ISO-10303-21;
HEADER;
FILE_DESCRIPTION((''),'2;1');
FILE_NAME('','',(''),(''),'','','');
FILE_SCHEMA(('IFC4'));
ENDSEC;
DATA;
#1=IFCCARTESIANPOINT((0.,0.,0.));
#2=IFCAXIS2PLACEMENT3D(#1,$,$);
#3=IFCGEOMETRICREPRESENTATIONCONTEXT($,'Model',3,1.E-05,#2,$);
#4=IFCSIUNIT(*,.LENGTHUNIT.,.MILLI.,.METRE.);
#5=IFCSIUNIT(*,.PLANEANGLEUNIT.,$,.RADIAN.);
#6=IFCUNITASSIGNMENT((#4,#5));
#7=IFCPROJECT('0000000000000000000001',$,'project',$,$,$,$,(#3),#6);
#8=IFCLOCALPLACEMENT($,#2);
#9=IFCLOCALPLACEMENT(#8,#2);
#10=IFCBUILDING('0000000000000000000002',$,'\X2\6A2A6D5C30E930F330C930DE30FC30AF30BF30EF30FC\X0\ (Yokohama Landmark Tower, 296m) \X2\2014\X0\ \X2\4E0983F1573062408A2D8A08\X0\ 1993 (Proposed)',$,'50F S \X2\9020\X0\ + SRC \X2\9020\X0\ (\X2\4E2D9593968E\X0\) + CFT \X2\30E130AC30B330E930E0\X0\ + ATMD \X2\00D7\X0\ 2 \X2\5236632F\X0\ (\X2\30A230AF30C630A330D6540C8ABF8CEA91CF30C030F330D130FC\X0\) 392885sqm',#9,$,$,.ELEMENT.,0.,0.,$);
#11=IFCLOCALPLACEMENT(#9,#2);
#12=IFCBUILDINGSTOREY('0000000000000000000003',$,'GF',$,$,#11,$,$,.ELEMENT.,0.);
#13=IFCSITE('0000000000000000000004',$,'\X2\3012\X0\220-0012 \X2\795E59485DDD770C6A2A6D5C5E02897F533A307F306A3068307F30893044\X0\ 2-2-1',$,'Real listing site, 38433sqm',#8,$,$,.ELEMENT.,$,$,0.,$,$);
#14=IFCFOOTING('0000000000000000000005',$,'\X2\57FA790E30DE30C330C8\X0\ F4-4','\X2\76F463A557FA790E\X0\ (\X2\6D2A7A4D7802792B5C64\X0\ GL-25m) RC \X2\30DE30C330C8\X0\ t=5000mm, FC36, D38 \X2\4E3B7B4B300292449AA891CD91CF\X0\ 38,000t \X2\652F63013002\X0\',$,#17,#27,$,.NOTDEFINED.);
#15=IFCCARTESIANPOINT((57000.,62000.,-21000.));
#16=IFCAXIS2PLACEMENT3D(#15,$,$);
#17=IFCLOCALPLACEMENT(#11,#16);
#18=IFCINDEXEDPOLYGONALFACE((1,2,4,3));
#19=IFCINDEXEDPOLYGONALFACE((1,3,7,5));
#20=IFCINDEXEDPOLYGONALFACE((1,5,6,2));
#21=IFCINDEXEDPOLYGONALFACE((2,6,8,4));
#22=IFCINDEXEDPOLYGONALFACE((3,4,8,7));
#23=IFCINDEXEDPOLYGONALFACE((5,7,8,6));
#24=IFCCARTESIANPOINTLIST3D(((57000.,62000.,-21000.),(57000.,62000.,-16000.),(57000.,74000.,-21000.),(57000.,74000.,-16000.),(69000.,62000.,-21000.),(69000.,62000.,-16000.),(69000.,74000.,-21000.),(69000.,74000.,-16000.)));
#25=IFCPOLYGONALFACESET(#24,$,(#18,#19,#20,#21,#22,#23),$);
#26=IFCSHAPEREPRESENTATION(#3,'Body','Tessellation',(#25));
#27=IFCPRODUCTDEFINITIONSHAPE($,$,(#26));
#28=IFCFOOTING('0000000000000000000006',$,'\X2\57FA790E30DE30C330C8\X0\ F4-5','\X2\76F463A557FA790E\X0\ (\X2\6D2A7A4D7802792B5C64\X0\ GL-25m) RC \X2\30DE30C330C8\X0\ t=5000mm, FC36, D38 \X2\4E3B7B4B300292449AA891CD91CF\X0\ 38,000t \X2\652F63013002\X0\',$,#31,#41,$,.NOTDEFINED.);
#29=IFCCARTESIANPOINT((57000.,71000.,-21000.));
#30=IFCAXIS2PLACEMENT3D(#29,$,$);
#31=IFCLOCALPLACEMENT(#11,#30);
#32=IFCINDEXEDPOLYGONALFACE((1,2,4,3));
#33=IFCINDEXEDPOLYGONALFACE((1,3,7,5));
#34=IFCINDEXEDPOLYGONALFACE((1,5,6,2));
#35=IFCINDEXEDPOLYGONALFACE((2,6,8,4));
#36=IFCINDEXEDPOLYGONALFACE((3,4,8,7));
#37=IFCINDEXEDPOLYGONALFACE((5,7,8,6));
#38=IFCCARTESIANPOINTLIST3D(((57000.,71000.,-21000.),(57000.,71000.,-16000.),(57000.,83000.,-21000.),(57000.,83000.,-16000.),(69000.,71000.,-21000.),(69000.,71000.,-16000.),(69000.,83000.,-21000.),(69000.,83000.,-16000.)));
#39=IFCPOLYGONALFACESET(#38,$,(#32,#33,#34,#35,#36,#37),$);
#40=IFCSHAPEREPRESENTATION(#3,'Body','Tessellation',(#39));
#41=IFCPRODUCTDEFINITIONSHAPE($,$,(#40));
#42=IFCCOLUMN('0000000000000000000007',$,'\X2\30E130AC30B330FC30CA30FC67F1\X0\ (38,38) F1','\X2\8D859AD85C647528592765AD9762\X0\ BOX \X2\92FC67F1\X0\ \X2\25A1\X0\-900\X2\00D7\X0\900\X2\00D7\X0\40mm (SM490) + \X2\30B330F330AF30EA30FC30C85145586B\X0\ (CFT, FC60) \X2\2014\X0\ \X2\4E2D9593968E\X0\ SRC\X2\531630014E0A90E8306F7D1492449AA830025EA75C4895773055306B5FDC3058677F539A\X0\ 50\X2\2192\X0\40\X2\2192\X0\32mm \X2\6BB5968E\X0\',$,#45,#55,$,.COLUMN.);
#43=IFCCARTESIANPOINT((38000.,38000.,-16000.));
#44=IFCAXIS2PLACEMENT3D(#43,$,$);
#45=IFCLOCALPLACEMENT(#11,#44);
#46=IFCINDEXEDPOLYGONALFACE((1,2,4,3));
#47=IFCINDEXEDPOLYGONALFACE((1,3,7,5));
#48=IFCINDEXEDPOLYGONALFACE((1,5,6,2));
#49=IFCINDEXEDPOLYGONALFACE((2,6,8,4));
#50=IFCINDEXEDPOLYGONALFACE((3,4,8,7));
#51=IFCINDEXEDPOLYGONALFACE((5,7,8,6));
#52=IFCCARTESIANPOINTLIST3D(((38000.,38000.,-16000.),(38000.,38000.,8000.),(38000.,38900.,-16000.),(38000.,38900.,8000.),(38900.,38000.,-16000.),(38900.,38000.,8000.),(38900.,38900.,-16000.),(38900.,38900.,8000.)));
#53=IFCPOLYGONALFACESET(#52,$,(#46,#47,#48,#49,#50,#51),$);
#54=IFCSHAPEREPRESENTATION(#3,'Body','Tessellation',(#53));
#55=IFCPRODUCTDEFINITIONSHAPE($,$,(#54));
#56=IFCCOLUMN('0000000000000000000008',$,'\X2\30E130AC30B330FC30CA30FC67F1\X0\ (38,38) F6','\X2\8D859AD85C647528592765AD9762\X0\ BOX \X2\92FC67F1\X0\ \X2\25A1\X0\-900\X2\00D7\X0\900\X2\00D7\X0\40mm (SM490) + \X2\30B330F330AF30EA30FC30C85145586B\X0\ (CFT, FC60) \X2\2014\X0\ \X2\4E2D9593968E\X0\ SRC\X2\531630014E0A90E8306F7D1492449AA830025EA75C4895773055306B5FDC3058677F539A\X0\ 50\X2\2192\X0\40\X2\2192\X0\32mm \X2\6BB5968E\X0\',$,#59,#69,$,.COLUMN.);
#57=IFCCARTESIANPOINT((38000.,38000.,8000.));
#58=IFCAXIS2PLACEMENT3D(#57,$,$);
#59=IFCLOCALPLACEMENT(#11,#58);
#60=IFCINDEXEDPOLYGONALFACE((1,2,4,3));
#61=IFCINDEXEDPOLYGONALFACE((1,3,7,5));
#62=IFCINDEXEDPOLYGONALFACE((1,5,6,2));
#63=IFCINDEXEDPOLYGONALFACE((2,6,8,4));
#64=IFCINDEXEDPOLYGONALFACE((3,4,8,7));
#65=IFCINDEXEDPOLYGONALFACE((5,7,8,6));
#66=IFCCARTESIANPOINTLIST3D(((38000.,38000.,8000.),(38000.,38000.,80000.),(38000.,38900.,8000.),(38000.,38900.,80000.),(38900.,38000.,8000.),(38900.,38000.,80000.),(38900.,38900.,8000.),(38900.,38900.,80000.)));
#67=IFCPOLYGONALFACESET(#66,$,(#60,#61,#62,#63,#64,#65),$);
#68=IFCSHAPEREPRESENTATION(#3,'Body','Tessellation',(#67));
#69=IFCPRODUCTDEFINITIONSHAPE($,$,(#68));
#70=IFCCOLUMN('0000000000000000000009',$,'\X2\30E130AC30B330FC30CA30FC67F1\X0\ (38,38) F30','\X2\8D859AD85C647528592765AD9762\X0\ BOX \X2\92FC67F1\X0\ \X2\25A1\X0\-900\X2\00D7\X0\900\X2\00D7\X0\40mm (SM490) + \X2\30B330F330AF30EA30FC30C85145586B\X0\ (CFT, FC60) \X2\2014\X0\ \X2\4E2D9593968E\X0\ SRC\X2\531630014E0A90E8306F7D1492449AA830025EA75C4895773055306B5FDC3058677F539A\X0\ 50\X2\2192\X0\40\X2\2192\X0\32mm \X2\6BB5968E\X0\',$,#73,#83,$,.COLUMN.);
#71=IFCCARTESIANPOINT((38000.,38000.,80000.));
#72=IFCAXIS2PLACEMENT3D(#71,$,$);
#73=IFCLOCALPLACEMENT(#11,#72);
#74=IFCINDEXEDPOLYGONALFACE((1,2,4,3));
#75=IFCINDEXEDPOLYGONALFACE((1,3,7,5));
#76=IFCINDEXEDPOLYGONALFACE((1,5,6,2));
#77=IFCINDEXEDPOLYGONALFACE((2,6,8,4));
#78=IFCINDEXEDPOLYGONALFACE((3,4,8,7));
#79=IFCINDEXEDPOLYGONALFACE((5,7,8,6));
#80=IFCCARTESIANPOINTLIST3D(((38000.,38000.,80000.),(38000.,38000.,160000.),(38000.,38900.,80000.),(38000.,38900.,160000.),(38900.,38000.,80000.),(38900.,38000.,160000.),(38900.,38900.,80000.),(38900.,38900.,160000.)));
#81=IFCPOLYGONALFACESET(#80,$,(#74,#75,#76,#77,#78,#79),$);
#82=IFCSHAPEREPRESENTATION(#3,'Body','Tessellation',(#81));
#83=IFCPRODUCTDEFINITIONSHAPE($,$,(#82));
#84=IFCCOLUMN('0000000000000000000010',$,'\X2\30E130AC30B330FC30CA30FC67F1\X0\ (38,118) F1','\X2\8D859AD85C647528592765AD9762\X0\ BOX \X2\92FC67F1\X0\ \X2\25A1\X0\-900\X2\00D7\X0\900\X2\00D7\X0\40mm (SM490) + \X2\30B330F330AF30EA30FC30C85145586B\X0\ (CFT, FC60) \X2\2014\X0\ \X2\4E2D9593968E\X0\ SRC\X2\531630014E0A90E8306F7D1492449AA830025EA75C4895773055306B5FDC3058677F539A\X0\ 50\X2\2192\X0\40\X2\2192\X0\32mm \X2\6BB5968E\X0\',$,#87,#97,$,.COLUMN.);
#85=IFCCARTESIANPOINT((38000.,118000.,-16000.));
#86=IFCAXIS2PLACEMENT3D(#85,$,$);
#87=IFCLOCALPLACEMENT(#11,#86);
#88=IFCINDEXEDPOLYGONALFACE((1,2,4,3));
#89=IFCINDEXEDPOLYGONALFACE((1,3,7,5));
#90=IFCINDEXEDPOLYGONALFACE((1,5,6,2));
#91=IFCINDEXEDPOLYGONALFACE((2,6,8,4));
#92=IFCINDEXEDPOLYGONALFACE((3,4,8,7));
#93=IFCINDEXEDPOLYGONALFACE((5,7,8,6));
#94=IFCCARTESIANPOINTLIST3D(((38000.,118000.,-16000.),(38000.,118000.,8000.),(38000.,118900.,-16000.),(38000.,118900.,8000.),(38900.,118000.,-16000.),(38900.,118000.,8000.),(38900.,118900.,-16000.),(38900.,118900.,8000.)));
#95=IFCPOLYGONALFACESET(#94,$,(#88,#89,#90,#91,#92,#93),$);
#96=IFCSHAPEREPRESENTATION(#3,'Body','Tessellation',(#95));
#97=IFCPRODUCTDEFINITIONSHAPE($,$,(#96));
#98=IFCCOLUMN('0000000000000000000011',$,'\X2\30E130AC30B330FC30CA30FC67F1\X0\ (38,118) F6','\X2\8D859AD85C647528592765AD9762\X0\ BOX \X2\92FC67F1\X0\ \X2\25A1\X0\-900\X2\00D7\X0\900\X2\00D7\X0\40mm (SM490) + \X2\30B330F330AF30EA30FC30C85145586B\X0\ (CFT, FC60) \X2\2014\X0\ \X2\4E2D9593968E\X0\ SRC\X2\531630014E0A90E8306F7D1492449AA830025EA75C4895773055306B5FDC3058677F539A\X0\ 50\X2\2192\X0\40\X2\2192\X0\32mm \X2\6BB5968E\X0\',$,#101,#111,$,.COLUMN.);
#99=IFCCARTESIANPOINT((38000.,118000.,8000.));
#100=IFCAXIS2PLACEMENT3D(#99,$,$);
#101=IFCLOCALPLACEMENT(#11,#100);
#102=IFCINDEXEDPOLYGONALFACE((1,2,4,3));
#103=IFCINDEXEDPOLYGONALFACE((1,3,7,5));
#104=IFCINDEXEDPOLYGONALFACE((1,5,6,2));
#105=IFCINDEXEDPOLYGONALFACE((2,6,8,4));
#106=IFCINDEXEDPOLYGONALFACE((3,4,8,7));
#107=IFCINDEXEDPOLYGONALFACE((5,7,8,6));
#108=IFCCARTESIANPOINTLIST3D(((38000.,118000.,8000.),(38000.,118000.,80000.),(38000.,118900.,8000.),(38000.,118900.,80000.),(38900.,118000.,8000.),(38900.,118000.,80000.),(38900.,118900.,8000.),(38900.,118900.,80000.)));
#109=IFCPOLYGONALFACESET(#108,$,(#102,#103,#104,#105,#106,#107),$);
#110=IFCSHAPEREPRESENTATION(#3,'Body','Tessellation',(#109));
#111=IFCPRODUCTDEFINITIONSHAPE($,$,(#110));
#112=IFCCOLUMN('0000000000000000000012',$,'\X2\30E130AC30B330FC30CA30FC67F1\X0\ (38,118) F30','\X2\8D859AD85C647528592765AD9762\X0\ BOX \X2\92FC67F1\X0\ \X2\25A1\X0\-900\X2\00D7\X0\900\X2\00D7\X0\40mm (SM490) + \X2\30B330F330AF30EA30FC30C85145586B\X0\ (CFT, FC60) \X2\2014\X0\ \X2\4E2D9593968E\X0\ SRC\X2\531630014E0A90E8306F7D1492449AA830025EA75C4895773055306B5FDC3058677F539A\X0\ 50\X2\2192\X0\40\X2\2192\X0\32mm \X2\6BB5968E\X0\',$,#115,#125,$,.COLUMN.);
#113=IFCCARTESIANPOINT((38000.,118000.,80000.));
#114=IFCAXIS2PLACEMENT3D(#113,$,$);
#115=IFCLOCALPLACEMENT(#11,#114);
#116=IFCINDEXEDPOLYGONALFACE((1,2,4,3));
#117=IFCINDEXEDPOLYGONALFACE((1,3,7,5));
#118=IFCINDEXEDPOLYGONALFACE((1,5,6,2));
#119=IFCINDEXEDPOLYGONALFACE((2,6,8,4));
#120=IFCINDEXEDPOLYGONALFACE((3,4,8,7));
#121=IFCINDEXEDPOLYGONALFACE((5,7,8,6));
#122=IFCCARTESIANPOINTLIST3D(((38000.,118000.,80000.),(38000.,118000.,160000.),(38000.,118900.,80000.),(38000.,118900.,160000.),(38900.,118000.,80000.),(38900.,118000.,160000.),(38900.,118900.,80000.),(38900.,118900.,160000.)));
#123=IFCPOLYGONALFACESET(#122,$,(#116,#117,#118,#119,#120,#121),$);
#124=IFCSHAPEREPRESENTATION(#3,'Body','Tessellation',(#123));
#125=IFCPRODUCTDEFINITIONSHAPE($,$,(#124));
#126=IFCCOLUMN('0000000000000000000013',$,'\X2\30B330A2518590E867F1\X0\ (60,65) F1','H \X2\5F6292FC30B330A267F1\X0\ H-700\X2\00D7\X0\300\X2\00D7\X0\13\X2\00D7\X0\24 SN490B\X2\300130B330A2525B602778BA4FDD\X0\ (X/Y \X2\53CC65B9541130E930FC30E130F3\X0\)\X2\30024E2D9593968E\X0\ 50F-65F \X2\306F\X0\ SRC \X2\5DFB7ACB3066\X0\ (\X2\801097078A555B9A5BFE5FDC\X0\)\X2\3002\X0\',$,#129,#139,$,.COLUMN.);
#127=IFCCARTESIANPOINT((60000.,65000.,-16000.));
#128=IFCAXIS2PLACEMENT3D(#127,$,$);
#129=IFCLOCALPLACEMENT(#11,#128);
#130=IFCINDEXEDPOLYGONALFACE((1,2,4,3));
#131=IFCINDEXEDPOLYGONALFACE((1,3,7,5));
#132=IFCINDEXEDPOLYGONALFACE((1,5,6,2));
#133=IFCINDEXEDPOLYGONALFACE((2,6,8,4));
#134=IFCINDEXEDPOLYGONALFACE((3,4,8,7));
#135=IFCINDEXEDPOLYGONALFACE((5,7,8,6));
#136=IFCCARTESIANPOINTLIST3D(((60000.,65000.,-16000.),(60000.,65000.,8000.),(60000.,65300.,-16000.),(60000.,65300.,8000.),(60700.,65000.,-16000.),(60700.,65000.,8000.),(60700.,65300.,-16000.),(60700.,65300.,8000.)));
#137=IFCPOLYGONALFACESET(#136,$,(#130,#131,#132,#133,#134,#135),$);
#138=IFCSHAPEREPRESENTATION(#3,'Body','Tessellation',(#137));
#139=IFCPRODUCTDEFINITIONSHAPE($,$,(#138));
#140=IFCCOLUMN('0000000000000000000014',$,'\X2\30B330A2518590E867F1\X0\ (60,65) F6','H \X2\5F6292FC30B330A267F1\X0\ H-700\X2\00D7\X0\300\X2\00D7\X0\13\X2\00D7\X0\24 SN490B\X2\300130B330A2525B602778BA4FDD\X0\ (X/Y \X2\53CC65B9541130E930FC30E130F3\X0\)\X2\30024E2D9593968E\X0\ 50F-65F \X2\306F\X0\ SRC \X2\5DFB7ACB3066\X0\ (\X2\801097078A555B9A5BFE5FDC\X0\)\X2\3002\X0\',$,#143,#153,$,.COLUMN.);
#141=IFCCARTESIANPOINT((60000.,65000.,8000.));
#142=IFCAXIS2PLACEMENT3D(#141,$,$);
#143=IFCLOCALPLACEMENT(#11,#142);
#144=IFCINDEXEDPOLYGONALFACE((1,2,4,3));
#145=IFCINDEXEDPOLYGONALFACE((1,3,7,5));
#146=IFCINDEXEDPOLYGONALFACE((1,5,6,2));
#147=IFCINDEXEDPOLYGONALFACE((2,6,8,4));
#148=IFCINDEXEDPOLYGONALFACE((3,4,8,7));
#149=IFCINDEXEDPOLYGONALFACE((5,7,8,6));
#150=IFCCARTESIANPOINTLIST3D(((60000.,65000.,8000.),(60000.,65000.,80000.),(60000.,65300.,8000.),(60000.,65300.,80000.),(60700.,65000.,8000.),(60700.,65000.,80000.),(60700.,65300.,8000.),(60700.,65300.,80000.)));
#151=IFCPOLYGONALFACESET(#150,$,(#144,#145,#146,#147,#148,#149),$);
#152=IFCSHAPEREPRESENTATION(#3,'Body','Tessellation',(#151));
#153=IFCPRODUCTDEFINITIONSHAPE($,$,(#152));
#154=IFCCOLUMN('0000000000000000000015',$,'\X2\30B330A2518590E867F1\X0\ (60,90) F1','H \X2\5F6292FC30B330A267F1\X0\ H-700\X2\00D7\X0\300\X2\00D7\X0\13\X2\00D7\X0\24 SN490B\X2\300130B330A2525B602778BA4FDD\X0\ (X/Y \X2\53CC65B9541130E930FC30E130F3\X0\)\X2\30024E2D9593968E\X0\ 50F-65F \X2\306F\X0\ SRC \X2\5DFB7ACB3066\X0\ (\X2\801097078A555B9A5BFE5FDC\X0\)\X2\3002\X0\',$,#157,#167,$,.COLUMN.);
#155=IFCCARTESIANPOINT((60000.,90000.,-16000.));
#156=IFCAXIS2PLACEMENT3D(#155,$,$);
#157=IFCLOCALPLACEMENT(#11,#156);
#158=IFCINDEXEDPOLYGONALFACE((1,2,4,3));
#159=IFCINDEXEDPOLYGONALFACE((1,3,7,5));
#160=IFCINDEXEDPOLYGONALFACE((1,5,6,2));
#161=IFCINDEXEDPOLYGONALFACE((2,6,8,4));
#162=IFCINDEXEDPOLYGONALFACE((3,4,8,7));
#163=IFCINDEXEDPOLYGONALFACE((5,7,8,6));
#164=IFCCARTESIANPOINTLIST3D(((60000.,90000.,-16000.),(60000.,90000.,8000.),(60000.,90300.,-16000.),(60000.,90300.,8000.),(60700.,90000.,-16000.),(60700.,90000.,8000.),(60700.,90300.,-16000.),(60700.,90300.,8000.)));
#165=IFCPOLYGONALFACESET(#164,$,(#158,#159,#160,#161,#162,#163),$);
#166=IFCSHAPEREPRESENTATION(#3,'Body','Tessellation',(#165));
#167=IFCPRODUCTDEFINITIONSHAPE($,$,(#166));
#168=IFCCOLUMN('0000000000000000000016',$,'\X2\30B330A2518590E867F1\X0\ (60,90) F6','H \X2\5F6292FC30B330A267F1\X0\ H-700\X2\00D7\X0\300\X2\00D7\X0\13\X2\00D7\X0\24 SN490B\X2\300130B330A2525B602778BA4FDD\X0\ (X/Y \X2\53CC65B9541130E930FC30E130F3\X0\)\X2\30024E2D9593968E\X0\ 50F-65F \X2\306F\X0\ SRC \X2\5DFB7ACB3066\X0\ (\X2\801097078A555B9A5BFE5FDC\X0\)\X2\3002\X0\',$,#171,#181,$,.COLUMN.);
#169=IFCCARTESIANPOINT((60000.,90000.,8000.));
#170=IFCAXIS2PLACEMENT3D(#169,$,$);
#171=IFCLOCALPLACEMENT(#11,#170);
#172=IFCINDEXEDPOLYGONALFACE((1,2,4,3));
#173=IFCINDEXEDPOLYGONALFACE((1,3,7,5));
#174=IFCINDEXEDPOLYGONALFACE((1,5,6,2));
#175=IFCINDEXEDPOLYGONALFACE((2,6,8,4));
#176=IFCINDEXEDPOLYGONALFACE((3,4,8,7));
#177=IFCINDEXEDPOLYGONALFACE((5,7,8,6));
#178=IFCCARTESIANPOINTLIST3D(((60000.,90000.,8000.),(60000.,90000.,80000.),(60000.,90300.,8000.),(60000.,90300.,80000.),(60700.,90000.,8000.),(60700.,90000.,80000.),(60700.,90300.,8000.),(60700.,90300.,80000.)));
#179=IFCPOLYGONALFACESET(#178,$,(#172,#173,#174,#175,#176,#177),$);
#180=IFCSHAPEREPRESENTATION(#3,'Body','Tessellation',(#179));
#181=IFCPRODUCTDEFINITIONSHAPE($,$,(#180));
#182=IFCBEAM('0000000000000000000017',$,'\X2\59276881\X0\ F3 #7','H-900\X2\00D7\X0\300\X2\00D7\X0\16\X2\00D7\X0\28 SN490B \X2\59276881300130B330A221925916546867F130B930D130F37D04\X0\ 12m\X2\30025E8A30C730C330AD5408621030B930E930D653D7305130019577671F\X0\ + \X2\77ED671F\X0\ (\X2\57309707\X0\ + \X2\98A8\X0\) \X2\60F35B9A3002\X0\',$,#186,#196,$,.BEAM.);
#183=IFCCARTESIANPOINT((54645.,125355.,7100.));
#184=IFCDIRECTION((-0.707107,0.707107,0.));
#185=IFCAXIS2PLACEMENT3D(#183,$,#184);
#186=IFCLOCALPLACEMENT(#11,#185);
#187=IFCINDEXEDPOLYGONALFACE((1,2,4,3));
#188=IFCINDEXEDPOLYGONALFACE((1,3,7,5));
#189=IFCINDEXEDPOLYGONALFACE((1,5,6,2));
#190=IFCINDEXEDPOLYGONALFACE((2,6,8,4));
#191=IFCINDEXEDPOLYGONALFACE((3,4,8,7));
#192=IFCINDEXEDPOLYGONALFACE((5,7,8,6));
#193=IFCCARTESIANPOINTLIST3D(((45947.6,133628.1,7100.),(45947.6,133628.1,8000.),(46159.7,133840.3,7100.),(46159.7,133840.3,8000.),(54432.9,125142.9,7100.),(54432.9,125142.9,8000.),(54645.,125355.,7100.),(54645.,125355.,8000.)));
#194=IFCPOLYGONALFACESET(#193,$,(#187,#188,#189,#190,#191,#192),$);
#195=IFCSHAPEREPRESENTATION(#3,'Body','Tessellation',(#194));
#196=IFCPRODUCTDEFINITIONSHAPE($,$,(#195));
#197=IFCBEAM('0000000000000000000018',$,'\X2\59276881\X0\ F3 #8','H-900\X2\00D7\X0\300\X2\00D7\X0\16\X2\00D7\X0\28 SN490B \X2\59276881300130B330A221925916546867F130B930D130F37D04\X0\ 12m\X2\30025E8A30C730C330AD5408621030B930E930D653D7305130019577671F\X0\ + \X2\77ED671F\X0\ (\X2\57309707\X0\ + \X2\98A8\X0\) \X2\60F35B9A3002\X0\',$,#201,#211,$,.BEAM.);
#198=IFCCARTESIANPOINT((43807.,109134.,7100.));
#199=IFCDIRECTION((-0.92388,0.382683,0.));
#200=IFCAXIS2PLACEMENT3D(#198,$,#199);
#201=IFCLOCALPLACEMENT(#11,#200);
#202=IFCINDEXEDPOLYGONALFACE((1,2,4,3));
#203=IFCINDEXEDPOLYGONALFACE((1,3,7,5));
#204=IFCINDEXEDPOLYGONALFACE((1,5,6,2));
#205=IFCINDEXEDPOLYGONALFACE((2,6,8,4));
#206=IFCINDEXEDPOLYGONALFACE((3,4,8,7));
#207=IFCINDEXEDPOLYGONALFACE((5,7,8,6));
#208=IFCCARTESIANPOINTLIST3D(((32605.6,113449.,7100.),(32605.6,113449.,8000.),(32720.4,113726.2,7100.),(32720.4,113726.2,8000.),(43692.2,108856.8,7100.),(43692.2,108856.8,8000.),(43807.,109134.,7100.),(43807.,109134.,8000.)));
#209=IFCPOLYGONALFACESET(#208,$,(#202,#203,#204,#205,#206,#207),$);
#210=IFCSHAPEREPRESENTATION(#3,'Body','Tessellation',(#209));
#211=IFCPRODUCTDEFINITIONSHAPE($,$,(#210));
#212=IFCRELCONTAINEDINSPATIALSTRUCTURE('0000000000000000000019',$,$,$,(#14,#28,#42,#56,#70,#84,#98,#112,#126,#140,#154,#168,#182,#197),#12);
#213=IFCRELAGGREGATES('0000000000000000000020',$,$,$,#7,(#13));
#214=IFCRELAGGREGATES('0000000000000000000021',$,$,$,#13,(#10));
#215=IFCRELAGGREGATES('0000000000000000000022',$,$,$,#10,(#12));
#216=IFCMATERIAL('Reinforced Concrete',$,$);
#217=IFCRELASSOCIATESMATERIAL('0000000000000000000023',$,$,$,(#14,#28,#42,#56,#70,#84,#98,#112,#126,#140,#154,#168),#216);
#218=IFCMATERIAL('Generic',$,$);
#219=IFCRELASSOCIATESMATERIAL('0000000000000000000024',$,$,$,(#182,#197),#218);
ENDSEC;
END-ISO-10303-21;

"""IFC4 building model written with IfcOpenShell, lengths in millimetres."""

from ifc_helpers import new_model, si_unit, frame, frame_2d, origin, place, context, project, spatial, rectangle, extrude, material, element, save


model = new_model("IFC4")

# Units and contexts
model_context = context("Model", 3, precision=1e-05, world=origin())
ifc_project = project(units=[si_unit("LENGTHUNIT", "METRE", prefix="MILLI"), si_unit("PLANEANGLEUNIT", "RADIAN")], contexts=[model_context])

# Site, building, storey
site_placement = place(None, origin())
site = spatial("IfcSite", under=ifc_project, at=site_placement, Name="〒220-0012 神奈川県横浜市西区みなとみらい 2-2-1", ObjectType="Real listing site, 38433sqm", CompositionType="ELEMENT", RefElevation=0.0)
building_placement = place(site_placement, origin())
building = spatial("IfcBuilding", under=site, at=building_placement, Name="横浜ランドマークタワー (Yokohama Landmark Tower, 296m) — 三菱地所設計 1993 (Proposed)", ObjectType="50F S 造 + SRC 造 (中間階) + CFT メガコラム + ATMD × 2 制振 (アクティブ同調質量ダンパー) 392885sqm", CompositionType="ELEMENT", ElevationOfRefHeight=0.0, ElevationOfTerrain=0.0)
storey_placement = place(building_placement, origin())
storey = spatial("IfcBuildingStorey", under=building, at=storey_placement, Name="GF", CompositionType="ELEMENT", Elevation=0.0)

# Footings
ifc_material_1 = material(Name="Reinforced Concrete")
footing_1_placement = place(storey_placement, frame((57000.0, 62000.0, -21000.0)))
element("IfcFooting", 1, at=footing_1_placement, inside=storey, material=ifc_material_1, Name="基礎マット F4-4", Description="直接基礎 (洪積砂礫層 GL-25m) RC マット t=5000mm, FC36, D38 主筋。鉄骨重量 38,000t 支持。", PredefinedType="NOTDEFINED", context=model_context, shape_type="SweptSolid", body=[
    extrude(rectangle(XDim=12000.0, YDim=12000.0, at=frame_2d((6000.0, 6000.0))), frame((57000.0, 62000.0, -21000.0)), (0.0, 0.0, 1.0), 5000.0),
])
footing_2_placement = place(storey_placement, frame((57000.0, 71000.0, -21000.0)))
element("IfcFooting", 2, at=footing_2_placement, inside=storey, material=ifc_material_1, Name="基礎マット F4-5", Description="直接基礎 (洪積砂礫層 GL-25m) RC マット t=5000mm, FC36, D38 主筋。鉄骨重量 38,000t 支持。", PredefinedType="NOTDEFINED", context=model_context, shape_type="SweptSolid", body=[
    extrude(rectangle(XDim=12000.0, YDim=12000.0, at=frame_2d((6000.0, 6000.0))), frame((57000.0, 71000.0, -21000.0)), (0.0, 0.0, 1.0), 5000.0),
])

# Columns
column_1_placement = place(storey_placement, frame((38000.0, 38000.0, -16000.0)))
element("IfcColumn", 3, at=column_1_placement, inside=storey, material=ifc_material_1, Name="メガコーナー柱 (38,38) F1", Description="超高層用大断面 BOX 鋼柱 □-900×900×40mm (SM490) + コンクリート充填 (CFT, FC60) — 中間階 SRC化、上部は純鉄骨。座屈長さに応じ板厚 50→40→32mm 段階", PredefinedType="COLUMN", context=model_context, shape_type="SweptSolid", body=[
    extrude(rectangle(XDim=900.0, YDim=900.0, at=frame_2d((450.0, 450.0))), frame((38000.0, 38000.0, -16000.0)), (0.0, 0.0, 1.0), 24000.0),
])
column_2_placement = place(storey_placement, frame((38000.0, 38000.0, 8000.0)))
element("IfcColumn", 4, at=column_2_placement, inside=storey, material=ifc_material_1, Name="メガコーナー柱 (38,38) F6", Description="超高層用大断面 BOX 鋼柱 □-900×900×40mm (SM490) + コンクリート充填 (CFT, FC60) — 中間階 SRC化、上部は純鉄骨。座屈長さに応じ板厚 50→40→32mm 段階", PredefinedType="COLUMN", context=model_context, shape_type="SweptSolid", body=[
    extrude(rectangle(XDim=900.0, YDim=900.0, at=frame_2d((450.0, 450.0))), frame((38000.0, 38000.0, 8000.0)), (0.0, 0.0, 1.0), 72000.0),
])
column_3_placement = place(storey_placement, frame((38000.0, 38000.0, 80000.0)))
element("IfcColumn", 5, at=column_3_placement, inside=storey, material=ifc_material_1, Name="メガコーナー柱 (38,38) F30", Description="超高層用大断面 BOX 鋼柱 □-900×900×40mm (SM490) + コンクリート充填 (CFT, FC60) — 中間階 SRC化、上部は純鉄骨。座屈長さに応じ板厚 50→40→32mm 段階", PredefinedType="COLUMN", context=model_context, shape_type="SweptSolid", body=[
    extrude(rectangle(XDim=900.0, YDim=900.0, at=frame_2d((450.0, 450.0))), frame((38000.0, 38000.0, 80000.0)), (0.0, 0.0, 1.0), 80000.0),
])
column_4_placement = place(storey_placement, frame((38000.0, 118000.0, -16000.0)))
element("IfcColumn", 6, at=column_4_placement, inside=storey, material=ifc_material_1, Name="メガコーナー柱 (38,118) F1", Description="超高層用大断面 BOX 鋼柱 □-900×900×40mm (SM490) + コンクリート充填 (CFT, FC60) — 中間階 SRC化、上部は純鉄骨。座屈長さに応じ板厚 50→40→32mm 段階", PredefinedType="COLUMN", context=model_context, shape_type="SweptSolid", body=[
    extrude(rectangle(XDim=900.0, YDim=900.0, at=frame_2d((450.0, 450.0))), frame((38000.0, 118000.0, -16000.0)), (0.0, 0.0, 1.0), 24000.0),
])
column_5_placement = place(storey_placement, frame((38000.0, 118000.0, 8000.0)))
element("IfcColumn", 7, at=column_5_placement, inside=storey, material=ifc_material_1, Name="メガコーナー柱 (38,118) F6", Description="超高層用大断面 BOX 鋼柱 □-900×900×40mm (SM490) + コンクリート充填 (CFT, FC60) — 中間階 SRC化、上部は純鉄骨。座屈長さに応じ板厚 50→40→32mm 段階", PredefinedType="COLUMN", context=model_context, shape_type="SweptSolid", body=[
    extrude(rectangle(XDim=900.0, YDim=900.0, at=frame_2d((450.0, 450.0))), frame((38000.0, 118000.0, 8000.0)), (0.0, 0.0, 1.0), 72000.0),
])
column_6_placement = place(storey_placement, frame((38000.0, 118000.0, 80000.0)))
element("IfcColumn", 8, at=column_6_placement, inside=storey, material=ifc_material_1, Name="メガコーナー柱 (38,118) F30", Description="超高層用大断面 BOX 鋼柱 □-900×900×40mm (SM490) + コンクリート充填 (CFT, FC60) — 中間階 SRC化、上部は純鉄骨。座屈長さに応じ板厚 50→40→32mm 段階", PredefinedType="COLUMN", context=model_context, shape_type="SweptSolid", body=[
    extrude(rectangle(XDim=900.0, YDim=900.0, at=frame_2d((450.0, 450.0))), frame((38000.0, 118000.0, 80000.0)), (0.0, 0.0, 1.0), 80000.0),
])
column_7_placement = place(storey_placement, frame((60000.0, 65000.0, -16000.0)))
element("IfcColumn", 9, at=column_7_placement, inside=storey, material=ifc_material_1, Name="コア内部柱 (60,65) F1", Description="H 形鋼コア柱 H-700×300×13×24 SN490B、コア剛性確保 (X/Y 双方向ラーメン)。中間階 50F-65F は SRC 巻立て (耐震評定対応)。", PredefinedType="COLUMN", context=model_context, shape_type="SweptSolid", body=[
    extrude(rectangle(XDim=700.0, YDim=300.0, at=frame_2d((350.0, 150.0))), frame((60000.0, 65000.0, -16000.0)), (0.0, 0.0, 1.0), 24000.0),
])
column_8_placement = place(storey_placement, frame((60000.0, 65000.0, 8000.0)))
element("IfcColumn", 10, at=column_8_placement, inside=storey, material=ifc_material_1, Name="コア内部柱 (60,65) F6", Description="H 形鋼コア柱 H-700×300×13×24 SN490B、コア剛性確保 (X/Y 双方向ラーメン)。中間階 50F-65F は SRC 巻立て (耐震評定対応)。", PredefinedType="COLUMN", context=model_context, shape_type="SweptSolid", body=[
    extrude(rectangle(XDim=700.0, YDim=300.0, at=frame_2d((350.0, 150.0))), frame((60000.0, 65000.0, 8000.0)), (0.0, 0.0, 1.0), 72000.0),
])
column_9_placement = place(storey_placement, frame((60000.0, 90000.0, -16000.0)))
element("IfcColumn", 11, at=column_9_placement, inside=storey, material=ifc_material_1, Name="コア内部柱 (60,90) F1", Description="H 形鋼コア柱 H-700×300×13×24 SN490B、コア剛性確保 (X/Y 双方向ラーメン)。中間階 50F-65F は SRC 巻立て (耐震評定対応)。", PredefinedType="COLUMN", context=model_context, shape_type="SweptSolid", body=[
    extrude(rectangle(XDim=700.0, YDim=300.0, at=frame_2d((350.0, 150.0))), frame((60000.0, 90000.0, -16000.0)), (0.0, 0.0, 1.0), 24000.0),
])
column_10_placement = place(storey_placement, frame((60000.0, 90000.0, 8000.0)))
element("IfcColumn", 12, at=column_10_placement, inside=storey, material=ifc_material_1, Name="コア内部柱 (60,90) F6", Description="H 形鋼コア柱 H-700×300×13×24 SN490B、コア剛性確保 (X/Y 双方向ラーメン)。中間階 50F-65F は SRC 巻立て (耐震評定対応)。", PredefinedType="COLUMN", context=model_context, shape_type="SweptSolid", body=[
    extrude(rectangle(XDim=700.0, YDim=300.0, at=frame_2d((350.0, 150.0))), frame((60000.0, 90000.0, 8000.0)), (0.0, 0.0, 1.0), 72000.0),
])

# Beams
ifc_material_2 = material(Name="Generic")
beam_1_placement = place(storey_placement, frame((54645.0, 125355.0, 7100.0), x_axis=(-0.707107, 0.707107, 0.0)))
element("IfcBeam", 13, at=beam_1_placement, inside=storey, material=ifc_material_2, Name="大梁 F3 #7", Description="H-900×300×16×28 SN490B 大梁、コア→外周柱スパン約 12m。床デッキ合成スラブ受け、長期 + 短期 (地震 + 風) 想定。", PredefinedType="BEAM", context=model_context, shape_type="SweptSolid", body=[
    extrude(rectangle(XDim=12000.0, YDim=300.0, at=frame_2d((6000.0, 150.0))), frame((54645.0, 125355.0, 7100.0), x_axis=(-0.707107, 0.707107, 0.0)), (0.0, 0.0, 1.0), 900.0),
])
beam_2_placement = place(storey_placement, frame((43807.0, 109134.0, 7100.0), x_axis=(-0.92388, 0.382683, 0.0)))
element("IfcBeam", 14, at=beam_2_placement, inside=storey, material=ifc_material_2, Name="大梁 F3 #8", Description="H-900×300×16×28 SN490B 大梁、コア→外周柱スパン約 12m。床デッキ合成スラブ受け、長期 + 短期 (地震 + 風) 想定。", PredefinedType="BEAM", context=model_context, shape_type="SweptSolid", body=[
    extrude(rectangle(XDim=12000.0, YDim=300.0, at=frame_2d((6000.0, 150.0))), frame((43807.0, 109134.0, 7100.0), x_axis=(-0.92388, 0.382683, 0.0)), (0.0, 0.0, 1.0), 900.0),
])

save(model, "model.ifc")
